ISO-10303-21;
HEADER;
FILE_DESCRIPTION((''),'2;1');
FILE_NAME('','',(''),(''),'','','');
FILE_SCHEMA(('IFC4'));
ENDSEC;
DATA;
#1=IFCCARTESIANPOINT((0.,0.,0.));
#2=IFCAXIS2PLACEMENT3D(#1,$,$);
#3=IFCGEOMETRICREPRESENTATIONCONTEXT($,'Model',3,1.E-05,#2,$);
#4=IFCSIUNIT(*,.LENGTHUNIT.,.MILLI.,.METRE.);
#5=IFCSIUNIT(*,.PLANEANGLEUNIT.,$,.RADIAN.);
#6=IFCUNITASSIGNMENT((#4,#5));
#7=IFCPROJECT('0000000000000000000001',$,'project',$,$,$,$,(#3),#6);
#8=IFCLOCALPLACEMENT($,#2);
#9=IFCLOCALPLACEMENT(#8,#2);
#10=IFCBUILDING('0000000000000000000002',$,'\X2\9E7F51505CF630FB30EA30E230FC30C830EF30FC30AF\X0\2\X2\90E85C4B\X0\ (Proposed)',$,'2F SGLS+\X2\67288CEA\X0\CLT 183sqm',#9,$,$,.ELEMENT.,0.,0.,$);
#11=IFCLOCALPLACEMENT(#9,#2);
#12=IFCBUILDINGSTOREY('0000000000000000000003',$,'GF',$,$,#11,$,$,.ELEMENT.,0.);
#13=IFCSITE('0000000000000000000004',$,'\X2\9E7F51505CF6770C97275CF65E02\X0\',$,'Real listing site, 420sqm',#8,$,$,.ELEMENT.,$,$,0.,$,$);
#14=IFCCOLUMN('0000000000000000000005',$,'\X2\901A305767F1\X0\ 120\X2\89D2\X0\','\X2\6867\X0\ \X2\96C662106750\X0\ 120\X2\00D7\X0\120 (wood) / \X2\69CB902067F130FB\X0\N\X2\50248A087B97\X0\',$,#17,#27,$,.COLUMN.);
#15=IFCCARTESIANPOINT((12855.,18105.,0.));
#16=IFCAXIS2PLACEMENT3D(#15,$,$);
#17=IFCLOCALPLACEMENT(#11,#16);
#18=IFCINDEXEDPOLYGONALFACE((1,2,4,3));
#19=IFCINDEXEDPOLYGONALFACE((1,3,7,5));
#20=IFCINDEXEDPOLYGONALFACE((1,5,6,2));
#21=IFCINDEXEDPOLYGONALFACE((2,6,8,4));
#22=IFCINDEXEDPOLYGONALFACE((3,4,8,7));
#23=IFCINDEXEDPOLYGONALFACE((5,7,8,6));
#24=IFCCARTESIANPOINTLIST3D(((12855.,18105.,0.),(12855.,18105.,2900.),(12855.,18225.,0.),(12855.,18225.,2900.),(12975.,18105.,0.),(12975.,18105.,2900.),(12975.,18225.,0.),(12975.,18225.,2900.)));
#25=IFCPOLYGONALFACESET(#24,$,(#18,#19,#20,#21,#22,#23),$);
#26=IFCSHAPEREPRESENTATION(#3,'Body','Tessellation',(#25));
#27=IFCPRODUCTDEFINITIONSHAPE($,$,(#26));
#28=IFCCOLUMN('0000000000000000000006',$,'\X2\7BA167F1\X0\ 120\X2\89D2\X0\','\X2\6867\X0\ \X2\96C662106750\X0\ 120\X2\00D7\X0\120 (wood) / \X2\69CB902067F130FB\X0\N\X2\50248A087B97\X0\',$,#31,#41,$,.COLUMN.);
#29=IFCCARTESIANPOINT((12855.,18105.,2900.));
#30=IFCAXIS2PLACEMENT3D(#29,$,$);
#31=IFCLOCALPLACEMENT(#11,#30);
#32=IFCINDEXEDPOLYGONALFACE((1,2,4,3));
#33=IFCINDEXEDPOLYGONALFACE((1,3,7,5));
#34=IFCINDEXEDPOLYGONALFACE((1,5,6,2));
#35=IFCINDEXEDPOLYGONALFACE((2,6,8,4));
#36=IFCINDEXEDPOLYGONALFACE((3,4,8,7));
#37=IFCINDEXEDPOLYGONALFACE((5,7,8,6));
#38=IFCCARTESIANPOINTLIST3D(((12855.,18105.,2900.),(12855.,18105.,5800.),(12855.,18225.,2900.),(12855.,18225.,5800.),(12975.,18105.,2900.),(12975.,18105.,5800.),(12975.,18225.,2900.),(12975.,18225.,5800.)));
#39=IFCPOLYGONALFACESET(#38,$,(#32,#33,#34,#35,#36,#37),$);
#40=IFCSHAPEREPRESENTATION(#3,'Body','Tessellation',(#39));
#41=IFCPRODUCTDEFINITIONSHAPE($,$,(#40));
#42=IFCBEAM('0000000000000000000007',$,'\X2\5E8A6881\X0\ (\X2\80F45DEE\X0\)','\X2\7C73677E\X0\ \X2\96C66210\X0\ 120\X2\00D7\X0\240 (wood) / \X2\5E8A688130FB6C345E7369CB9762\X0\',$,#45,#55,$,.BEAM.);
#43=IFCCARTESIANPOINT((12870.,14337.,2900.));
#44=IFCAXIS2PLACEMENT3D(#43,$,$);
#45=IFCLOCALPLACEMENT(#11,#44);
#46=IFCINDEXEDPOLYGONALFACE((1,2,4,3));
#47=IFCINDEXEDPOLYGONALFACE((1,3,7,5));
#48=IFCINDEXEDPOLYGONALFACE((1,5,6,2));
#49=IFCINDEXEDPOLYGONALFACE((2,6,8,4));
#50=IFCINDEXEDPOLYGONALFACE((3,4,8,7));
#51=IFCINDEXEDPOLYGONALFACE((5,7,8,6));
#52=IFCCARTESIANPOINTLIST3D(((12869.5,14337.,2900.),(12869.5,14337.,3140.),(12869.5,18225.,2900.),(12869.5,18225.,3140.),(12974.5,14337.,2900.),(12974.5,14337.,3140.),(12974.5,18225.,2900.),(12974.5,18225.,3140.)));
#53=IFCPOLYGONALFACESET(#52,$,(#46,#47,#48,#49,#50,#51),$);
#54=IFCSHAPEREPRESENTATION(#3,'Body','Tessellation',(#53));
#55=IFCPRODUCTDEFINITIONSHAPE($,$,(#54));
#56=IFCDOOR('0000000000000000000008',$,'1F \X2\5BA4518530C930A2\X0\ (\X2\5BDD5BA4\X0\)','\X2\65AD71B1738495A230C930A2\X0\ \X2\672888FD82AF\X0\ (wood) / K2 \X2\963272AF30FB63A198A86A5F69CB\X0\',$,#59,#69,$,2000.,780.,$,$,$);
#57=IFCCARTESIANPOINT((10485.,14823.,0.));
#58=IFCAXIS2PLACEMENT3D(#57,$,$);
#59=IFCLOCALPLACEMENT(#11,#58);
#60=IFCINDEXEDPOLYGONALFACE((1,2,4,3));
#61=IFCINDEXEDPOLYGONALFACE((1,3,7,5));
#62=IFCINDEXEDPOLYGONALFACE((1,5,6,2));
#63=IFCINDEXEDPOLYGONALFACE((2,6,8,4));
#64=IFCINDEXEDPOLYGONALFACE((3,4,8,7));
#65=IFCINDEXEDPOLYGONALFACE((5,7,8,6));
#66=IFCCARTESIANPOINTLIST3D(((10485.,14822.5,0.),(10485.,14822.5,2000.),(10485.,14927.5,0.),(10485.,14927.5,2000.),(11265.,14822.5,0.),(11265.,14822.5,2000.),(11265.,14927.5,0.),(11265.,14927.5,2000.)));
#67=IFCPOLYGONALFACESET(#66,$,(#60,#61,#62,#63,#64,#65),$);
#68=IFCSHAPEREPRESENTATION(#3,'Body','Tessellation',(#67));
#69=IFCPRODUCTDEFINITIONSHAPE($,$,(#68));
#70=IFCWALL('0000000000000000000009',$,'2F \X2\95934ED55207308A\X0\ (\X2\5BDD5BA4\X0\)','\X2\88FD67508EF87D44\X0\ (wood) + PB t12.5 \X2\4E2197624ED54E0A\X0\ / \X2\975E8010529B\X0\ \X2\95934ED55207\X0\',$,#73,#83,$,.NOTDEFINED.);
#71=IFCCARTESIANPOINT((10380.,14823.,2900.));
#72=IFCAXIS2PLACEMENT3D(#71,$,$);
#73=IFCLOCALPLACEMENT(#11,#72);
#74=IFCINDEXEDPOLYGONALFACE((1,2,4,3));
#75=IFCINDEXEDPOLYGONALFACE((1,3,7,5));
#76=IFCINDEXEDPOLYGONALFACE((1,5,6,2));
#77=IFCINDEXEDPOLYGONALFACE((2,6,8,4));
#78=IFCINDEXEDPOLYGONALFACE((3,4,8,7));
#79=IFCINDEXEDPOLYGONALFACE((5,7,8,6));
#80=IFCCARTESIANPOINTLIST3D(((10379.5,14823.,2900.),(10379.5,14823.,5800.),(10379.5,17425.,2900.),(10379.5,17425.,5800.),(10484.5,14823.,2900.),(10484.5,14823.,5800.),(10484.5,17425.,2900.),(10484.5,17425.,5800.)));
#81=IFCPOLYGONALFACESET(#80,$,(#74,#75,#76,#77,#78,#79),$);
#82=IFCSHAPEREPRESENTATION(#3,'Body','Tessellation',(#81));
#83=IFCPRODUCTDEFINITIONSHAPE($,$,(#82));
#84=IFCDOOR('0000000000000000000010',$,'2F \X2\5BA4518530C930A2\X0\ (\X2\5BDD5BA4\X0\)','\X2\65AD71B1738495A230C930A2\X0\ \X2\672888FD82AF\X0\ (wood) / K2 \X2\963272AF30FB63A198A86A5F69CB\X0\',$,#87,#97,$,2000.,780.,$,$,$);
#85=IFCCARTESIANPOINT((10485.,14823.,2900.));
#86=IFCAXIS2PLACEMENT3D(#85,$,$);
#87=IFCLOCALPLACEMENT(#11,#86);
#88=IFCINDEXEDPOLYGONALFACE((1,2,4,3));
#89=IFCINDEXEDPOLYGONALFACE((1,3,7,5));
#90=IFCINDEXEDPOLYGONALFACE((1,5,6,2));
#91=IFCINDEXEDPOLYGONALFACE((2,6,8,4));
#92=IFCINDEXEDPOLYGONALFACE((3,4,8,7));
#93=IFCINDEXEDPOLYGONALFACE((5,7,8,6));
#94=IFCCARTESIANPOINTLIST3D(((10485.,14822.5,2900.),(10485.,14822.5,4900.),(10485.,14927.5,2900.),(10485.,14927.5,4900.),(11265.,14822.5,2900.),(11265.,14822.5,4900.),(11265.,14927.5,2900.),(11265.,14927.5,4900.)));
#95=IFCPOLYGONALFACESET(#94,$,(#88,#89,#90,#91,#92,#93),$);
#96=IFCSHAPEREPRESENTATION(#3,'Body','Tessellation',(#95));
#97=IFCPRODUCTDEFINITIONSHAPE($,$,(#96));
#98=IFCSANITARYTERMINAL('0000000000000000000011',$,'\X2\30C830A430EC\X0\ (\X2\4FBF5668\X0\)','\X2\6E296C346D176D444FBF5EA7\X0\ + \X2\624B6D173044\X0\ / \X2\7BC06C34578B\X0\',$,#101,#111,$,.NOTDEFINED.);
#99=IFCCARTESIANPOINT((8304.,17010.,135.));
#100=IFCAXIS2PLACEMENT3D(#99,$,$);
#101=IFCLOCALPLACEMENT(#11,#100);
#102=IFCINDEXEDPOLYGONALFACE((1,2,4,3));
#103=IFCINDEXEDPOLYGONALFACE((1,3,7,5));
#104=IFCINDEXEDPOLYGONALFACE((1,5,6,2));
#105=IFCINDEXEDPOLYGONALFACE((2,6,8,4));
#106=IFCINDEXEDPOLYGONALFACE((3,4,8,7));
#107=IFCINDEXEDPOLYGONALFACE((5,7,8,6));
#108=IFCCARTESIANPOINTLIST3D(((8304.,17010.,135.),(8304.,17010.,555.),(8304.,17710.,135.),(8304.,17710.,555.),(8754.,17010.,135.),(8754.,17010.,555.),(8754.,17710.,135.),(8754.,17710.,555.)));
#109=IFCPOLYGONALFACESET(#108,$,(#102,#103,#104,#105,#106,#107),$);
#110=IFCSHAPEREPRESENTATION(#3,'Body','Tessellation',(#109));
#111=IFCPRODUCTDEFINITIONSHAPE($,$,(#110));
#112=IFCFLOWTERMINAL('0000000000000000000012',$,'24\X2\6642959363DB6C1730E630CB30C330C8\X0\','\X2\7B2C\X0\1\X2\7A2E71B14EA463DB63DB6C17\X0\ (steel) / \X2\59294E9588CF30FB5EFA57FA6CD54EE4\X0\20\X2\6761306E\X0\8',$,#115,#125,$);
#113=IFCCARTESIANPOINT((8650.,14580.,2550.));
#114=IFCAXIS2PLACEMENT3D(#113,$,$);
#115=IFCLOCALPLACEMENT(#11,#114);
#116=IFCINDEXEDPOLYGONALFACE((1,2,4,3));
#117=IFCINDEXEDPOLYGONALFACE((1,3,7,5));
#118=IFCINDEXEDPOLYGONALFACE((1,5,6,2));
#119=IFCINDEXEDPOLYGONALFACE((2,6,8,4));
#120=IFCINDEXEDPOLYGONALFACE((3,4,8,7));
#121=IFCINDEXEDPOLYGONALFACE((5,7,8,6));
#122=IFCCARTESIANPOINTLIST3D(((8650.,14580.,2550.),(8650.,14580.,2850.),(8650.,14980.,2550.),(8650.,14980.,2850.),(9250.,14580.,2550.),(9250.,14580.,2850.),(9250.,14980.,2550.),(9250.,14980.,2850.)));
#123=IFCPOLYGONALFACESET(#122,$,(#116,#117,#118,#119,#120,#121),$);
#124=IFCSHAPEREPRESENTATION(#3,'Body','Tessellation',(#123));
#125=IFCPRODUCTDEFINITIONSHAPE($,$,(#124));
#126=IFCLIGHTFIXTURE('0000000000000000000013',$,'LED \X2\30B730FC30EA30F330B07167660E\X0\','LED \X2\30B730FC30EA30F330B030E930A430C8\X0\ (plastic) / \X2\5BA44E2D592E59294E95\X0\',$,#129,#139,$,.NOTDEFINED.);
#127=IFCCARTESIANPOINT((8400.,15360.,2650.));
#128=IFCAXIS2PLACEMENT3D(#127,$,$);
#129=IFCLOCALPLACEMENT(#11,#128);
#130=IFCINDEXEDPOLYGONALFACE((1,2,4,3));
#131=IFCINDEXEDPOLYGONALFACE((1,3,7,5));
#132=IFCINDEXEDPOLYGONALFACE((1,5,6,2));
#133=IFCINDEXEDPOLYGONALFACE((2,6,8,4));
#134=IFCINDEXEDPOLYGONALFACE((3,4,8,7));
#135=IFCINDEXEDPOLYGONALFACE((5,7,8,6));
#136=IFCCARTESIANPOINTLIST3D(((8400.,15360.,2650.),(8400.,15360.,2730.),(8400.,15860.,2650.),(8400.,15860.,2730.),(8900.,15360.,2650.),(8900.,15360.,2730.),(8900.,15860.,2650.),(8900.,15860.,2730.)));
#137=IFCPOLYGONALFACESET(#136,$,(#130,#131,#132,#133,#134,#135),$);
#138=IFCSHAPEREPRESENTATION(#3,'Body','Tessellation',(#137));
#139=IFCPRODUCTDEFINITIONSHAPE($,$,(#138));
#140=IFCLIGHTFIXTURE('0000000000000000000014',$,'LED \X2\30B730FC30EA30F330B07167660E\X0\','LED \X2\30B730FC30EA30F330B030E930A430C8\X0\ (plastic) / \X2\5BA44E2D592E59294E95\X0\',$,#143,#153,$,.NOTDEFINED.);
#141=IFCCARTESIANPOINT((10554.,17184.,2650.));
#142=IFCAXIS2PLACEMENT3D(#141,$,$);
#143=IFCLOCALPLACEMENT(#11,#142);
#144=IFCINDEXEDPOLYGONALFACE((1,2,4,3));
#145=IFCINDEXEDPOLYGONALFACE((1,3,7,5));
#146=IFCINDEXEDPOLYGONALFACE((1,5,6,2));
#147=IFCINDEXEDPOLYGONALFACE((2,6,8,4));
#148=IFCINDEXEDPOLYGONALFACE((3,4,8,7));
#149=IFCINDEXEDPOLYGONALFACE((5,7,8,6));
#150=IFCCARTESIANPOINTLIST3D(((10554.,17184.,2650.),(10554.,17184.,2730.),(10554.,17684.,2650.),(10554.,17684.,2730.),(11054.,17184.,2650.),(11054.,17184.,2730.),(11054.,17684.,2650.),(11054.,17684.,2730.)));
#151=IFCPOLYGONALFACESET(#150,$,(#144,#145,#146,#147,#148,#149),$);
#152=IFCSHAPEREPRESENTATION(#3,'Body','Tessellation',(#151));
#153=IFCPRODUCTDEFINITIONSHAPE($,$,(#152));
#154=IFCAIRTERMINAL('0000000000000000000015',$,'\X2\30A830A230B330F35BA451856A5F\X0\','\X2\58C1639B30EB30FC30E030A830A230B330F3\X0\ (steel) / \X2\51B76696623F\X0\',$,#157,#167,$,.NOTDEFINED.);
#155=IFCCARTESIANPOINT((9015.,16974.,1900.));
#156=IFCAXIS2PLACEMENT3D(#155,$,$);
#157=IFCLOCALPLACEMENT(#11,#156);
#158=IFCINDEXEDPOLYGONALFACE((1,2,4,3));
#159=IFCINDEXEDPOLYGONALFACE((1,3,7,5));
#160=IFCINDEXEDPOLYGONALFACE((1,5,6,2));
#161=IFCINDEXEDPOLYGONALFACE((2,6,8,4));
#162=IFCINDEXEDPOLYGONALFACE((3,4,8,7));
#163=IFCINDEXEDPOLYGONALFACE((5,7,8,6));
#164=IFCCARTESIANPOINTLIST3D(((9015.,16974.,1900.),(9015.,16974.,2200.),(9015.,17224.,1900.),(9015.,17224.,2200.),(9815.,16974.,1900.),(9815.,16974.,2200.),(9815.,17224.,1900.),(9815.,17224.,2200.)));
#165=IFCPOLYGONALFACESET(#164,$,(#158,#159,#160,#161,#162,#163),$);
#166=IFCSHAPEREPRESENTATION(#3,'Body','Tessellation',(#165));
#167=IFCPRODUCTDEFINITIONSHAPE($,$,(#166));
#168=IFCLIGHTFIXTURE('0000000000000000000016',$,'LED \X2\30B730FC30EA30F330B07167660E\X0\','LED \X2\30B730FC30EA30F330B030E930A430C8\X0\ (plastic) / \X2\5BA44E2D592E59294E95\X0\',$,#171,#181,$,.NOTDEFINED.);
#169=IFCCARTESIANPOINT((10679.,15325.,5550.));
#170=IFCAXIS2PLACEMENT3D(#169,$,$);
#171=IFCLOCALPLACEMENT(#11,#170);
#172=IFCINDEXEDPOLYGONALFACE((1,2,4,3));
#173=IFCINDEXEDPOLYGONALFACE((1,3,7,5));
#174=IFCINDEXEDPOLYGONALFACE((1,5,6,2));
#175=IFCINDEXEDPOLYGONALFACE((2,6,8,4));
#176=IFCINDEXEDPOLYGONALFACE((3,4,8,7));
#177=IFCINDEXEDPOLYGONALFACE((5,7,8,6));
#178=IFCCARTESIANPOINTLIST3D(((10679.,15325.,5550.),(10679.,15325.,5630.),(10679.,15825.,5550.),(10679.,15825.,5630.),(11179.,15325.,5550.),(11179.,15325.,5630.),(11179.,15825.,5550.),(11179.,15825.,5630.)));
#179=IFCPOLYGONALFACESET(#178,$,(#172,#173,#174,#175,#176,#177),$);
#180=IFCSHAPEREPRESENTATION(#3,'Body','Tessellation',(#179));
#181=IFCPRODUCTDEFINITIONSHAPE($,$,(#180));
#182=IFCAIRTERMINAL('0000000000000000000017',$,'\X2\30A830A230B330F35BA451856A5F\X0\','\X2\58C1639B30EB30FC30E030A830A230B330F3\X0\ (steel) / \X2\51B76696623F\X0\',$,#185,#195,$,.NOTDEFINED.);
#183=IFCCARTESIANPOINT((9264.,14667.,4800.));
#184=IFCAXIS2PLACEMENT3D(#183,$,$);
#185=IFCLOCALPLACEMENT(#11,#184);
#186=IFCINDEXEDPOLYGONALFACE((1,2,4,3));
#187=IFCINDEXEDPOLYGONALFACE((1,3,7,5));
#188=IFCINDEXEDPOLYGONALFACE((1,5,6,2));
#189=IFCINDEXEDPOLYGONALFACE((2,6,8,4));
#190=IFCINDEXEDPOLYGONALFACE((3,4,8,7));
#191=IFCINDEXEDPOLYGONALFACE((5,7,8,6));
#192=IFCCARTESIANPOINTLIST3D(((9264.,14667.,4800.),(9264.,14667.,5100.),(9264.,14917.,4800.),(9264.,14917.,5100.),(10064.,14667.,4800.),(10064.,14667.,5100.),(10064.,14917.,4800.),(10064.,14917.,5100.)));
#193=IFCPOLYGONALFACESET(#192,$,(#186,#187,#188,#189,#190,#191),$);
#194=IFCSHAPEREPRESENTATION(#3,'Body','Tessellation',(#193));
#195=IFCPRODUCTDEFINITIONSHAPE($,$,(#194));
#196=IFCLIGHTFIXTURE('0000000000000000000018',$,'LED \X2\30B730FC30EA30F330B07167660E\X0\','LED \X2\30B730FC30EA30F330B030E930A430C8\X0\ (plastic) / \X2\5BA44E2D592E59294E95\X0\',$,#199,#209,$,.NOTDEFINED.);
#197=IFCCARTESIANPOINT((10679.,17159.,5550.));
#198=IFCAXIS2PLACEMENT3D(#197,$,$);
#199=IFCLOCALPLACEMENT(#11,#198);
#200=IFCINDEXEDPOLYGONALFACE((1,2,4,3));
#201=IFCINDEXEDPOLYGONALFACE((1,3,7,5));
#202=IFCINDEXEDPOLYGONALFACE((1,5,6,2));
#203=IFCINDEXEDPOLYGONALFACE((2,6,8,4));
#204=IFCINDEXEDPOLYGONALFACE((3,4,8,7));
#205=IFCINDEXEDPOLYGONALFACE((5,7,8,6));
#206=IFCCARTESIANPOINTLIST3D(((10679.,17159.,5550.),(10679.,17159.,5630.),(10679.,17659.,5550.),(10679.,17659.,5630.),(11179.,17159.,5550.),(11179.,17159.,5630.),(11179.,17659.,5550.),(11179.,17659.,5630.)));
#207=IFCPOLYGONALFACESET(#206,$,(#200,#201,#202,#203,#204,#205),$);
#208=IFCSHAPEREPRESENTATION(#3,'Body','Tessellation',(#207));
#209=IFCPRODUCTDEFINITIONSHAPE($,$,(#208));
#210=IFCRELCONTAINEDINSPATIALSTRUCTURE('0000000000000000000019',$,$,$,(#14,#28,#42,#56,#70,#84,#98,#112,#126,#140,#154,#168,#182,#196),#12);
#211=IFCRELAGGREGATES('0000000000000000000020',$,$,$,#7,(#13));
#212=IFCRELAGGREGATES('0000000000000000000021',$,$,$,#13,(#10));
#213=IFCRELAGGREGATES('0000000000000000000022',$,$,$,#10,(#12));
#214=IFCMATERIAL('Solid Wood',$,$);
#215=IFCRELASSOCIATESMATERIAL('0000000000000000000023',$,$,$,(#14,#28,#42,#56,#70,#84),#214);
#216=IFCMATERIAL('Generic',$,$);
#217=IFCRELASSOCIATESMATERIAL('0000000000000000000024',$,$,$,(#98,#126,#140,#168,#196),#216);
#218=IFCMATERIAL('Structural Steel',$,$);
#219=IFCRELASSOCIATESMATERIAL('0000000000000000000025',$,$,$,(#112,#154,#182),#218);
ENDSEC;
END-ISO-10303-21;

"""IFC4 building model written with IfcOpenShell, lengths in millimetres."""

from ifc_helpers import new_model, si_unit, frame, frame_2d, origin, place, context, project, spatial, rectangle, extrude, material, element, save


model = new_model("IFC4")

# Units and contexts
model_context = context("Model", 3, precision=1e-05, world=origin())
ifc_project = project(units=[si_unit("LENGTHUNIT", "METRE", prefix="MILLI"), si_unit("PLANEANGLEUNIT", "RADIAN")], contexts=[model_context])

# Site, building, storey
site_placement = place(None, origin())
site = spatial("IfcSite", under=ifc_project, at=site_placement, Name="鹿児島県霧島市", ObjectType="Real listing site, 420sqm", CompositionType="ELEMENT", RefElevation=0.0)
building_placement = place(site_placement, origin())
building = spatial("IfcBuilding", under=site, at=building_placement, Name="鹿児島・リモートワーク2部屋 (Proposed)", ObjectType="2F SGLS+木質CLT 183sqm", CompositionType="ELEMENT", ElevationOfRefHeight=0.0, ElevationOfTerrain=0.0)
storey_placement = place(building_placement, origin())
storey = spatial("IfcBuildingStorey", under=building, at=storey_placement, Name="GF", CompositionType="ELEMENT", Elevation=0.0)

# Columns
ifc_material_1 = material(Name="Solid Wood")
column_1_placement = place(storey_placement, frame((12855.0, 18105.0, 0.0)))
element("IfcColumn", 1, at=column_1_placement, inside=storey, material=ifc_material_1, Name="通し柱 120角", Description="桧 集成材 120×120 (wood) / 構造柱・N値計算", PredefinedType="COLUMN", context=model_context, shape_type="SweptSolid", body=[
    extrude(rectangle(XDim=120.0, YDim=120.0, at=frame_2d((60.0, 60.0))), frame((12855.0, 18105.0, 0.0)), (0.0, 0.0, 1.0), 2900.0),
])
column_2_placement = place(storey_placement, frame((12855.0, 18105.0, 2900.0)))
element("IfcColumn", 2, at=column_2_placement, inside=storey, material=ifc_material_1, Name="管柱 120角", Description="桧 集成材 120×120 (wood) / 構造柱・N値計算", PredefinedType="COLUMN", context=model_context, shape_type="SweptSolid", body=[
    extrude(rectangle(XDim=120.0, YDim=120.0, at=frame_2d((60.0, 60.0))), frame((12855.0, 18105.0, 2900.0)), (0.0, 0.0, 1.0), 2900.0),
])

# Beam
beam_1_placement = place(storey_placement, frame((12870.0, 14337.0, 2900.0)))
element("IfcBeam", 3, at=beam_1_placement, inside=storey, material=ifc_material_1, Name="床梁 (胴差)", Description="米松 集成 120×240 (wood) / 床梁・水平構面", PredefinedType="BEAM", context=model_context, shape_type="SweptSolid", body=[
    extrude(rectangle(XDim=105.0, YDim=3888.0, at=frame_2d((52.0, 1944.0))), frame((12870.0, 14337.0, 2900.0)), (0.0, 0.0, 1.0), 240.0),
])

# Door
door_1_placement = place(storey_placement, frame((10485.0, 14823.0, 0.0)))
element("IfcDoor", 4, at=door_1_placement, inside=storey, material=ifc_material_1, Name="1F 室内ドア (寝室)", Description="断熱玄関ドア 木製芯 (wood) / K2 防犯・採風機構", OverallHeight=2000.0, OverallWidth=780.0, context=model_context, shape_type="SweptSolid", body=[
    extrude(rectangle(XDim=780.0, YDim=105.0, at=frame_2d((390.0, 52.0))), frame((10485.0, 14823.0, 0.0)), (0.0, 0.0, 1.0), 2000.0),
])

# Wall
wall_1_placement = place(storey_placement, frame((10380.0, 14823.0, 2900.0)))
element("IfcWall", 5, at=wall_1_placement, inside=storey, material=ifc_material_1, Name="2F 間仕切り (寝室)", Description="製材軸組 (wood) + PB t12.5 両面仕上 / 非耐力 間仕切", PredefinedType="NOTDEFINED", context=model_context, shape_type="SweptSolid", body=[
    extrude(rectangle(XDim=105.0, YDim=2602.0, at=frame_2d((52.0, 1301.0))), frame((10380.0, 14823.0, 2900.0)), (0.0, 0.0, 1.0), 2900.0),
])

# Door
door_2_placement = place(storey_placement, frame((10485.0, 14823.0, 2900.0)))
element("IfcDoor", 6, at=door_2_placement, inside=storey, material=ifc_material_1, Name="2F 室内ドア (寝室)", Description="断熱玄関ドア 木製芯 (wood) / K2 防犯・採風機構", OverallHeight=2000.0, OverallWidth=780.0, context=model_context, shape_type="SweptSolid", body=[
    extrude(rectangle(XDim=780.0, YDim=105.0, at=frame_2d((390.0, 52.0))), frame((10485.0, 14823.0, 2900.0)), (0.0, 0.0, 1.0), 2000.0),
])

# Sanitary terminal
ifc_material_2 = material(Name="Generic")
sanitary_terminal_placement = place(storey_placement, frame((8304.0, 17010.0, 135.0)))
element("IfcSanitaryTerminal", 7, at=sanitary_terminal_placement, inside=storey, material=ifc_material_2, Name="トイレ (便器)", Description="温水洗浄便座 + 手洗い / 節水型", PredefinedType="NOTDEFINED", context=model_context, shape_type="SweptSolid", body=[
    extrude(rectangle(XDim=450.0, YDim=700.0, at=frame_2d((225.0, 350.0))), frame((8304.0, 17010.0, 135.0)), (0.0, 0.0, 1.0), 420.0),
])

# Flow terminal
ifc_material_3 = material(Name="Structural Steel")
flow_terminal_placement = place(storey_placement, frame((8650.0, 14580.0, 2550.0)))
element("IfcFlowTerminal", 8, at=flow_terminal_placement, inside=storey, material=ifc_material_3, Name="24時間換気ユニット", Description="第1種熱交換換気 (steel) / 天井裏・建基法令20条の8", context=model_context, shape_type="SweptSolid", body=[
    extrude(rectangle(XDim=600.0, YDim=400.0, at=frame_2d((300.0, 200.0))), frame((8650.0, 14580.0, 2550.0)), (0.0, 0.0, 1.0), 300.0),
])

# Light fixtures
light_fixture_1_placement = place(storey_placement, frame((8400.0, 15360.0, 2650.0)))
element("IfcLightFixture", 9, at=light_fixture_1_placement, inside=storey, material=ifc_material_2, Name="LED シーリング照明", Description="LED シーリングライト (plastic) / 室中央天井", PredefinedType="NOTDEFINED", context=model_context, shape_type="SweptSolid", body=[
    extrude(rectangle(XDim=500.0, YDim=500.0, at=frame_2d((250.0, 250.0))), frame((8400.0, 15360.0, 2650.0)), (0.0, 0.0, 1.0), 80.0),
])
light_fixture_2_placement = place(storey_placement, frame((10554.0, 17184.0, 2650.0)))
element("IfcLightFixture", 10, at=light_fixture_2_placement, inside=storey, material=ifc_material_2, Name="LED シーリング照明", Description="LED シーリングライト (plastic) / 室中央天井", PredefinedType="NOTDEFINED", context=model_context, shape_type="SweptSolid", body=[
    extrude(rectangle(XDim=500.0, YDim=500.0, at=frame_2d((250.0, 250.0))), frame((10554.0, 17184.0, 2650.0)), (0.0, 0.0, 1.0), 80.0),
])

# Air terminal
air_terminal_1_placement = place(storey_placement, frame((9015.0, 16974.0, 1900.0)))
element("IfcAirTerminal", 11, at=air_terminal_1_placement, inside=storey, material=ifc_material_3, Name="エアコン室内機", Description="壁掛ルームエアコン (steel) / 冷暖房", PredefinedType="NOTDEFINED", context=model_context, shape_type="SweptSolid", body=[
    extrude(rectangle(XDim=800.0, YDim=250.0, at=frame_2d((400.0, 125.0))), frame((9015.0, 16974.0, 1900.0)), (0.0, 0.0, 1.0), 300.0),
])

# Light fixture
light_fixture_3_placement = place(storey_placement, frame((10679.0, 15325.0, 5550.0)))
element("IfcLightFixture", 12, at=light_fixture_3_placement, inside=storey, material=ifc_material_2, Name="LED シーリング照明", Description="LED シーリングライト (plastic) / 室中央天井", PredefinedType="NOTDEFINED", context=model_context, shape_type="SweptSolid", body=[
    extrude(rectangle(XDim=500.0, YDim=500.0, at=frame_2d((250.0, 250.0))), frame((10679.0, 15325.0, 5550.0)), (0.0, 0.0, 1.0), 80.0),
])

# Air terminal
air_terminal_2_placement = place(storey_placement, frame((9264.0, 14667.0, 4800.0)))
element("IfcAirTerminal", 13, at=air_terminal_2_placement, inside=storey, material=ifc_material_3, Name="エアコン室内機", Description="壁掛ルームエアコン (steel) / 冷暖房", PredefinedType="NOTDEFINED", context=model_context, shape_type="SweptSolid", body=[
    extrude(rectangle(XDim=800.0, YDim=250.0, at=frame_2d((400.0, 125.0))), frame((9264.0, 14667.0, 4800.0)), (0.0, 0.0, 1.0), 300.0),
])

# Light fixture
light_fixture_4_placement = place(storey_placement, frame((10679.0, 17159.0, 5550.0)))
element("IfcLightFixture", 14, at=light_fixture_4_placement, inside=storey, material=ifc_material_2, Name="LED シーリング照明", Description="LED シーリングライト (plastic) / 室中央天井", PredefinedType="NOTDEFINED", context=model_context, shape_type="SweptSolid", body=[
    extrude(rectangle(XDim=500.0, YDim=500.0, at=frame_2d((250.0, 250.0))), frame((10679.0, 17159.0, 5550.0)), (0.0, 0.0, 1.0), 80.0),
])

save(model, "model.ifc")
